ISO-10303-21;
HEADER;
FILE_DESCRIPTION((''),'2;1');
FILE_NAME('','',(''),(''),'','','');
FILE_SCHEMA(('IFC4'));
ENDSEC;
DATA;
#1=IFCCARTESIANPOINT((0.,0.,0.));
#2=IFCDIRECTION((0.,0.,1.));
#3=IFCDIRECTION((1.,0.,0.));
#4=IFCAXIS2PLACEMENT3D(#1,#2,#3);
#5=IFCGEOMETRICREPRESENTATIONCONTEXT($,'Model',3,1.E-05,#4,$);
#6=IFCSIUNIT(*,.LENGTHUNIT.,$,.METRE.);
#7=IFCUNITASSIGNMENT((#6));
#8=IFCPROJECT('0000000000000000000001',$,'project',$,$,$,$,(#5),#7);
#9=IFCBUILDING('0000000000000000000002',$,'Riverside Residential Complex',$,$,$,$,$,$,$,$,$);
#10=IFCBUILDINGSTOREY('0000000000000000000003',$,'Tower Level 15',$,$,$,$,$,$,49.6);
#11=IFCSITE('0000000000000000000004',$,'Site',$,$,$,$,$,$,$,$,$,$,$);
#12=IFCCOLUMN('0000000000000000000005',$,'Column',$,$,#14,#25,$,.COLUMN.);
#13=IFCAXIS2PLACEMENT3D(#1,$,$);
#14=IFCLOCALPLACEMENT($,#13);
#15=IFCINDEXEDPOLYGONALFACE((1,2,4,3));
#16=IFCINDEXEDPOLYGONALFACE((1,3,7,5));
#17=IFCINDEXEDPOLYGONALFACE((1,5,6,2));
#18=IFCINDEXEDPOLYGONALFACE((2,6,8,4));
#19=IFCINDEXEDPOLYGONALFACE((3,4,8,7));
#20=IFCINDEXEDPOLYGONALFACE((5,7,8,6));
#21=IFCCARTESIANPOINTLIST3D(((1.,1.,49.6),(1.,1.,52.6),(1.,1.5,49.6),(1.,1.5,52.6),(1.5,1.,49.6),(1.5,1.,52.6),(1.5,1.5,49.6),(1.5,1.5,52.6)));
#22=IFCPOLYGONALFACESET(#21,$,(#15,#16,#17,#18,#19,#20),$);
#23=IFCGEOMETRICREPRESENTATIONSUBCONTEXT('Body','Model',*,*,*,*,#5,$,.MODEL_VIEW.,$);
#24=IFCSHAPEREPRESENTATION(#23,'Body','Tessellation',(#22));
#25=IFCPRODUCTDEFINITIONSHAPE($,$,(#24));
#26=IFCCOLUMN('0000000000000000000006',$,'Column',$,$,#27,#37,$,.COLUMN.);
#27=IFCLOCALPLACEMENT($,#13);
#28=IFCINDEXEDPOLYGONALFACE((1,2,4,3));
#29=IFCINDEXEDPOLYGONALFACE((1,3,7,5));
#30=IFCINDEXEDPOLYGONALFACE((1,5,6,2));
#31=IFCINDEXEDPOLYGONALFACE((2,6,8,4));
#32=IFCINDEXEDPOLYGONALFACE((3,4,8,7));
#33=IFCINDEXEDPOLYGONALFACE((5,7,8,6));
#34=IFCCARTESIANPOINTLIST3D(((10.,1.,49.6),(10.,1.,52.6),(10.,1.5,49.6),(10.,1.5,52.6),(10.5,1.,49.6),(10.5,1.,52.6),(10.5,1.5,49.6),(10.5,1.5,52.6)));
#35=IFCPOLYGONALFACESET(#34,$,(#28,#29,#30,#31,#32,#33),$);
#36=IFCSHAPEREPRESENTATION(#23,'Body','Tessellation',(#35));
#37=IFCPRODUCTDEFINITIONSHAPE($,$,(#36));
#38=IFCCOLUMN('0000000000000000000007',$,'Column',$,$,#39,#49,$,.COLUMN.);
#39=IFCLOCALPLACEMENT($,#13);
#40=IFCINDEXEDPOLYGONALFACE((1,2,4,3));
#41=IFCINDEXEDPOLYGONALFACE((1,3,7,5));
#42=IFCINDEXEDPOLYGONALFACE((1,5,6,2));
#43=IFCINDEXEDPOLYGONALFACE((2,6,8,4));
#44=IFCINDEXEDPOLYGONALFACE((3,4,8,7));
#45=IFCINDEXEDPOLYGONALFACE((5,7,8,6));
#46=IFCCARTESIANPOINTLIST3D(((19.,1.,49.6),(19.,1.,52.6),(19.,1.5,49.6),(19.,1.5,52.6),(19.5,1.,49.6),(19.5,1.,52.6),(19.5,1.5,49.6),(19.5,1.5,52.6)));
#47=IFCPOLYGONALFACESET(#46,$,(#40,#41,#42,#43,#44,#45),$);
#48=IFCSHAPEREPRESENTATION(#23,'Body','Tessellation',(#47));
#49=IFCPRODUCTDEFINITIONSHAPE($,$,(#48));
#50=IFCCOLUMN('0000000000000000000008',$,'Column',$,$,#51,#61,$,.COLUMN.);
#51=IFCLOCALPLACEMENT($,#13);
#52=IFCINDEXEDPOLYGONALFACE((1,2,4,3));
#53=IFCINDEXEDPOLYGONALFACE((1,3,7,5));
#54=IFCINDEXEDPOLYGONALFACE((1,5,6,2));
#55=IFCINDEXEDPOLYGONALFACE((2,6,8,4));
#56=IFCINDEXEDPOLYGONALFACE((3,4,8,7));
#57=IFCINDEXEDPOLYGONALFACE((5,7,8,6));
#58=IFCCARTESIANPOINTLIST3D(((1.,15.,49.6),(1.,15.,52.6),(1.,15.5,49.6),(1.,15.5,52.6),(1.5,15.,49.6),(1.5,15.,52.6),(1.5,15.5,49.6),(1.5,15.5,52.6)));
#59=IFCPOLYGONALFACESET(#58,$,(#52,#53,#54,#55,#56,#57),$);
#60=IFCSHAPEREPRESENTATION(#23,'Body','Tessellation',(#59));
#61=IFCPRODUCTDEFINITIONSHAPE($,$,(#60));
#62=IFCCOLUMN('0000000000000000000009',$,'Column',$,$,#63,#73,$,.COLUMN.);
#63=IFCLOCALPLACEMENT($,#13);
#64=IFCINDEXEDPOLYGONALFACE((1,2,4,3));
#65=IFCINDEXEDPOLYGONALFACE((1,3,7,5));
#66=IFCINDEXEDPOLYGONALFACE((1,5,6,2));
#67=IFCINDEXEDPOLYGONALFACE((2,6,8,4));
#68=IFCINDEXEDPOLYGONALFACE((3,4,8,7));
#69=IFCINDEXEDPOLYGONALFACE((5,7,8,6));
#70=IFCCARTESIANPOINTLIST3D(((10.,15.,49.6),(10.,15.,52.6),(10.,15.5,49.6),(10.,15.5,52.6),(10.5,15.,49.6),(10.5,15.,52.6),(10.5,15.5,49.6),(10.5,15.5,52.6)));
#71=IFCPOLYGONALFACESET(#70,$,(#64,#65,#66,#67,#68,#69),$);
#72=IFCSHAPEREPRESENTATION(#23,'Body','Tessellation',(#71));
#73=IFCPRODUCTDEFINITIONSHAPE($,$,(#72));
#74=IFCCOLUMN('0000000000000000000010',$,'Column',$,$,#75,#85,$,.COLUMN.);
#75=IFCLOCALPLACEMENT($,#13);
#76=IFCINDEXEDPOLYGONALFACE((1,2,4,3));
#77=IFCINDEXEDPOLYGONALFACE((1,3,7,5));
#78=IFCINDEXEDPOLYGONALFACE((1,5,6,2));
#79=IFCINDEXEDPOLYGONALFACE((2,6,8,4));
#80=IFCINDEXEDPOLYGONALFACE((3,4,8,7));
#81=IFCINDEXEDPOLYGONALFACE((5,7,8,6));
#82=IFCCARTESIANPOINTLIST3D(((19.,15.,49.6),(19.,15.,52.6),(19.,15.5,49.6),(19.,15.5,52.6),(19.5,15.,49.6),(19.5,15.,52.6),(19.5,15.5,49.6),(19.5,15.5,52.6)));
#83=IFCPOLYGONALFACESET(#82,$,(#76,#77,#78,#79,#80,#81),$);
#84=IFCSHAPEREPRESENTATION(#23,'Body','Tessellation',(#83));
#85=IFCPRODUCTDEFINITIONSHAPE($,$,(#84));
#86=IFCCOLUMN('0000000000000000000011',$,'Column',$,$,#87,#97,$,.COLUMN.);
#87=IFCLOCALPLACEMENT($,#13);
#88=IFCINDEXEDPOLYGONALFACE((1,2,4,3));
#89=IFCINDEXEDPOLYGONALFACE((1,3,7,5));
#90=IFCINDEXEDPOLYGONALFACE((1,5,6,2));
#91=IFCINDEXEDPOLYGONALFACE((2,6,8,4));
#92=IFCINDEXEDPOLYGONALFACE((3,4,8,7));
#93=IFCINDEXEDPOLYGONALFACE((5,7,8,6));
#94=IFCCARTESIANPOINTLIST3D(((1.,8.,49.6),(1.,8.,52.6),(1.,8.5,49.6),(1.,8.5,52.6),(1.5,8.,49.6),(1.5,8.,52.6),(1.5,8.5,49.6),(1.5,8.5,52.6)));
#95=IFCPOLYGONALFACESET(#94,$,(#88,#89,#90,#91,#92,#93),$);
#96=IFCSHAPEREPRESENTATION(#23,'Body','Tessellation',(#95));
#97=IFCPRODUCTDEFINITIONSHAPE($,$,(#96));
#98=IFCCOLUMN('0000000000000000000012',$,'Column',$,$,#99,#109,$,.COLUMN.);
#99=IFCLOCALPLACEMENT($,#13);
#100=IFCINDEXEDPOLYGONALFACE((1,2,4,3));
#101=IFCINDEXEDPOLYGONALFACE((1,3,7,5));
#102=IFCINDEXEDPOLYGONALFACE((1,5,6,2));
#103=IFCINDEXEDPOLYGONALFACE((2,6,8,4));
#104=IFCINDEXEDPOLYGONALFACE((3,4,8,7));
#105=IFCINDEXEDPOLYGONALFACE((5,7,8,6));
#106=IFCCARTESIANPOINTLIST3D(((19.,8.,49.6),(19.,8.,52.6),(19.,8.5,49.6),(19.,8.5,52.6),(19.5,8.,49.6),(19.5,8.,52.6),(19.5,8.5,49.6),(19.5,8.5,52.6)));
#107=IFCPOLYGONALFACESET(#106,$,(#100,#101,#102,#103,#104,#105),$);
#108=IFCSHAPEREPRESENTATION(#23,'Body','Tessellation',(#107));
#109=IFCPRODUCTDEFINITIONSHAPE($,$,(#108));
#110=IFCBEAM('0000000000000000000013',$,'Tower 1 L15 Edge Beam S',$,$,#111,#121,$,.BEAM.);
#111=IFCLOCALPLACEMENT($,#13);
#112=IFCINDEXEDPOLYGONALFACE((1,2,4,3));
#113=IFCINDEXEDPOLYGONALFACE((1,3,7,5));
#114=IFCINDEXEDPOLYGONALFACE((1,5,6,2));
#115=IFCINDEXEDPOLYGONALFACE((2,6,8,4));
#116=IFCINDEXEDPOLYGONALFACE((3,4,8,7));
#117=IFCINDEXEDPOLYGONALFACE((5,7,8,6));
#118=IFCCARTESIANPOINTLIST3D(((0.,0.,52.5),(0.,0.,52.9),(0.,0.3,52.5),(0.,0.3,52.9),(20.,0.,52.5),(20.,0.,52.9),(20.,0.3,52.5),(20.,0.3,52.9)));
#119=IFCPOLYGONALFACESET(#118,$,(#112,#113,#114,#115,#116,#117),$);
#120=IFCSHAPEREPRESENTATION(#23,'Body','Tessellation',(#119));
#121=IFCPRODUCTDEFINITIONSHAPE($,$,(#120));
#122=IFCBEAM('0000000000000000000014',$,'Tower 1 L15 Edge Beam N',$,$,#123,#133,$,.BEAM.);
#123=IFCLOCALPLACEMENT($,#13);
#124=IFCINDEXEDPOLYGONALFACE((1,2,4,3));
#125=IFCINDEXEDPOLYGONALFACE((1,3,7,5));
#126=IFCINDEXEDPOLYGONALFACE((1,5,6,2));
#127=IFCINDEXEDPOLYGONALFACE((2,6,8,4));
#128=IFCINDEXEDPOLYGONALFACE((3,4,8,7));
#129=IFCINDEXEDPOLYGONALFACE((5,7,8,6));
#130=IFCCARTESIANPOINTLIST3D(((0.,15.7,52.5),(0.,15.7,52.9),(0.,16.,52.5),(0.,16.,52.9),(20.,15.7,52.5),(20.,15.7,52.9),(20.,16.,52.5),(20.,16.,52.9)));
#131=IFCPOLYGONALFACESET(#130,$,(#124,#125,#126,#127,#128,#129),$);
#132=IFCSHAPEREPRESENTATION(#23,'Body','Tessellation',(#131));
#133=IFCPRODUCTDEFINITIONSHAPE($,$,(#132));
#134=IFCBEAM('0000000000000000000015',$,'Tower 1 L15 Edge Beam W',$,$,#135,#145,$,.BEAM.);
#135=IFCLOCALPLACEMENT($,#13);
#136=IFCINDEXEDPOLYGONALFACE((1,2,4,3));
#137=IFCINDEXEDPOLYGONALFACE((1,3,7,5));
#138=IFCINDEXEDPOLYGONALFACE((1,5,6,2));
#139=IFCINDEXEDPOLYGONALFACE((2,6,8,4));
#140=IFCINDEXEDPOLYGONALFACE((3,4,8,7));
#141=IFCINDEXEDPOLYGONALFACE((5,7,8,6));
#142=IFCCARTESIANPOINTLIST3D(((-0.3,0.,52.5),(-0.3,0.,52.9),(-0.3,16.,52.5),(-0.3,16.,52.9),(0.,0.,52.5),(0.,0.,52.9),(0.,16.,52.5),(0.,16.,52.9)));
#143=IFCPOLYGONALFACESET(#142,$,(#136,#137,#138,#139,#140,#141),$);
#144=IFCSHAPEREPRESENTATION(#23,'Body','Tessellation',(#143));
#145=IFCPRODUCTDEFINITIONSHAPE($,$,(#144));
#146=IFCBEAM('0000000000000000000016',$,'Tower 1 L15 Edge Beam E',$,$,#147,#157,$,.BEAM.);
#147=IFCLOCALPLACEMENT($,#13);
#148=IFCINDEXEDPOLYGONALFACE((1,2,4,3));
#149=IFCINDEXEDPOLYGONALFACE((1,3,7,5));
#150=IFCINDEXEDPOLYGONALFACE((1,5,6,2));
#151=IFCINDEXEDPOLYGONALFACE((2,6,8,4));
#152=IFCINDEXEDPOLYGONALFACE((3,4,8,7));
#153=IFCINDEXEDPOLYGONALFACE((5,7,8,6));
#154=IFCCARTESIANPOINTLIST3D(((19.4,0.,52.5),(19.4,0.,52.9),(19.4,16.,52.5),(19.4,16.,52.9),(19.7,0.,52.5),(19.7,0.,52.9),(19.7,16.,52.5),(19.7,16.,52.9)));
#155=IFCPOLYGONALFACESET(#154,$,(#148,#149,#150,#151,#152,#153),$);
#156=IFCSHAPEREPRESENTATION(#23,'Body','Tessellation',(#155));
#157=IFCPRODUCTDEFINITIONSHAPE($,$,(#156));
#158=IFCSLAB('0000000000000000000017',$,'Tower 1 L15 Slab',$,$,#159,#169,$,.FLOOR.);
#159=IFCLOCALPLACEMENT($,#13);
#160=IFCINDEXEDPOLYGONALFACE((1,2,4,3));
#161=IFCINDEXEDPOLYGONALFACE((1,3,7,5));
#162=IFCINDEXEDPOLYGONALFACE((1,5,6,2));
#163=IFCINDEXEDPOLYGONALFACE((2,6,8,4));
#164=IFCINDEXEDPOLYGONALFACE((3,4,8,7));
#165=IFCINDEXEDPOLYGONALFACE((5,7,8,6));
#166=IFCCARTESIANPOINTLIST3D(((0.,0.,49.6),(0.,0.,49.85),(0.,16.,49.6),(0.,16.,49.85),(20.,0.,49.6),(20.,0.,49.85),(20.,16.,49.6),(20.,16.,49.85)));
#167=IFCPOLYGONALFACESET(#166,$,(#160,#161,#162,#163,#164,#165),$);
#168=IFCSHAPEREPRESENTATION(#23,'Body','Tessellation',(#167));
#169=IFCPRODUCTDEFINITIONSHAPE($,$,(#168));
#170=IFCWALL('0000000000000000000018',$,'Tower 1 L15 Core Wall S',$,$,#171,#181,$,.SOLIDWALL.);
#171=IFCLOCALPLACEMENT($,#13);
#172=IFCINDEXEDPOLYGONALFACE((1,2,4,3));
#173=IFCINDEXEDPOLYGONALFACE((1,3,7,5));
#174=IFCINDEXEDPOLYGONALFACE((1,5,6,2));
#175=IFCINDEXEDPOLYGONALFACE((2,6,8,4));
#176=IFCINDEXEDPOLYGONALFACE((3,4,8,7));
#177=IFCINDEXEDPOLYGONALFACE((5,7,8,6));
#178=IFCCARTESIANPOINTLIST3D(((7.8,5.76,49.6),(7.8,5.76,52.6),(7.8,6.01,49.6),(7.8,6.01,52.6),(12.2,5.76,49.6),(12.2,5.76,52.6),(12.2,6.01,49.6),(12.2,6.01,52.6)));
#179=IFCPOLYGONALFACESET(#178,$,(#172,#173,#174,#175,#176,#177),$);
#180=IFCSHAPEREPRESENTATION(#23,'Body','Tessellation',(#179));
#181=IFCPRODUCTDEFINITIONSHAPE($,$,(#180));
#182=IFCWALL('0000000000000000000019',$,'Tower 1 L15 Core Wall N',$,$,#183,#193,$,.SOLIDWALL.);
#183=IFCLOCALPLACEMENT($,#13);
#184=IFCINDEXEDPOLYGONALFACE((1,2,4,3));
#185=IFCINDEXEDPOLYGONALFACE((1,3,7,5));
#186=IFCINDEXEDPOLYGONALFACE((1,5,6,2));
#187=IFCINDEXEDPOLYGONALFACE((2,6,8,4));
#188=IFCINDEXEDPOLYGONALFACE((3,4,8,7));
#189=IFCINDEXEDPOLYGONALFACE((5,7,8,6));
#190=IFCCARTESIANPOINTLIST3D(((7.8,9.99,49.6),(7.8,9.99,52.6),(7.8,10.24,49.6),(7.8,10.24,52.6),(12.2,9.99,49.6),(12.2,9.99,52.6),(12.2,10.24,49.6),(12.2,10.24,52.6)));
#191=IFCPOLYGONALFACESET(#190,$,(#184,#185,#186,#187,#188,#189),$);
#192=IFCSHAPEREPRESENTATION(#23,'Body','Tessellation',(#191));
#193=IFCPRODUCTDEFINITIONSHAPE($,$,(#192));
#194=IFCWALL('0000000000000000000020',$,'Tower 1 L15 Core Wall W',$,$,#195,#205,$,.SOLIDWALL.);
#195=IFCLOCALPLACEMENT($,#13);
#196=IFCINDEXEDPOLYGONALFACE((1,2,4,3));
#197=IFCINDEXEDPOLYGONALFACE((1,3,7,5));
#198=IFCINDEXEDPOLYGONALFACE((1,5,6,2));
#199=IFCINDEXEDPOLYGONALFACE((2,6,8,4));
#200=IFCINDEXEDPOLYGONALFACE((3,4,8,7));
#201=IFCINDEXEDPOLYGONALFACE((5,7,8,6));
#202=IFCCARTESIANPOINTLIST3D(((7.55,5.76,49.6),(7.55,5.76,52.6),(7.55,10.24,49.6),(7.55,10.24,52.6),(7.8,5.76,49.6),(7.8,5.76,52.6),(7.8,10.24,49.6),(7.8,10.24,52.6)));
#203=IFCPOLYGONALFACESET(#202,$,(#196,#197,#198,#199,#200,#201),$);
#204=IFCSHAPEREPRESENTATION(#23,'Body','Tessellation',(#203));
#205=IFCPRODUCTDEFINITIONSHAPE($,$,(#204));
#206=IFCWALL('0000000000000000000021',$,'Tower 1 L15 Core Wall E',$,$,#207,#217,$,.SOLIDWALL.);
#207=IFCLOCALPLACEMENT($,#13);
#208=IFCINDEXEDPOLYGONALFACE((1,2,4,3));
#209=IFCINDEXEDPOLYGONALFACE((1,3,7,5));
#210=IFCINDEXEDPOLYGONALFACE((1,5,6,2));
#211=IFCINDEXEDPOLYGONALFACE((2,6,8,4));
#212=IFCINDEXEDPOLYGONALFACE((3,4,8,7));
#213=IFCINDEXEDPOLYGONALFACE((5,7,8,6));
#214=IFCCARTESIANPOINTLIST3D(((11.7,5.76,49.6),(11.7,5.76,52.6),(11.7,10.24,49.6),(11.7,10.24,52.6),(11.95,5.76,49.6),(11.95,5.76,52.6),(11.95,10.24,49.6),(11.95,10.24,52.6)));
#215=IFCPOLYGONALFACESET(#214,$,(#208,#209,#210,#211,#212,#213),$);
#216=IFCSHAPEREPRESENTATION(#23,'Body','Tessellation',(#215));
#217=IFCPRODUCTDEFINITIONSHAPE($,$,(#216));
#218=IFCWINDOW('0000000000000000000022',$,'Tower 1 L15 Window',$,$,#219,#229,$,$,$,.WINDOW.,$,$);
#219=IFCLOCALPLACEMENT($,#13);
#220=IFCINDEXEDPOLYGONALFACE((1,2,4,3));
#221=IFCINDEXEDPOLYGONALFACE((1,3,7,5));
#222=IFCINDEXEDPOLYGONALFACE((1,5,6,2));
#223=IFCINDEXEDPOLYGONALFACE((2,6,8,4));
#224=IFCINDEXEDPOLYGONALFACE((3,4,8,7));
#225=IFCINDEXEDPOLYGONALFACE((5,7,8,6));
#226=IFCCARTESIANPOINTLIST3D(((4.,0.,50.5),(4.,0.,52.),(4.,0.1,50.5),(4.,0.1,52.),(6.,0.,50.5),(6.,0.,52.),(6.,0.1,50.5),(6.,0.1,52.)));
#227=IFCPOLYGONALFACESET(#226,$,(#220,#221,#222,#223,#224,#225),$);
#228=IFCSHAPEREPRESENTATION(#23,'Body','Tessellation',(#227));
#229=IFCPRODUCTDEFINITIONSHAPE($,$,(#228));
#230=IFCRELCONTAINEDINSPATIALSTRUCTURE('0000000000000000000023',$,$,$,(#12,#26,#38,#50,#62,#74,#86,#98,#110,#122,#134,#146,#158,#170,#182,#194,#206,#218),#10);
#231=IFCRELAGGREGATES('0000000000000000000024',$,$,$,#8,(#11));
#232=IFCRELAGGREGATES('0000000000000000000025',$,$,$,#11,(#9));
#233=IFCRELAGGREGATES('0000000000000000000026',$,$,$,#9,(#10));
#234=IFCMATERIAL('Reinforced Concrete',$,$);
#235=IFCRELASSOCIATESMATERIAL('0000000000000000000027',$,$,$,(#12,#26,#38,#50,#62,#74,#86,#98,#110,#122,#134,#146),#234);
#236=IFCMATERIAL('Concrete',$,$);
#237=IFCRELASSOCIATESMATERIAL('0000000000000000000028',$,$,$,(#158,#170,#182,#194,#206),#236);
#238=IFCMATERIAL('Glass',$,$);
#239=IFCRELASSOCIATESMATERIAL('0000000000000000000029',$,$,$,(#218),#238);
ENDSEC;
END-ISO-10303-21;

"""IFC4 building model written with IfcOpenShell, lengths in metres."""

from ifc_helpers import new_model, si_unit, frame, origin_with_axes, place, context, subcontext, project, spatial, line, indexed_curve, outline, extrude, material, element, save


model = new_model("IFC4")

# Units and contexts
model_context = context("Model", 3, precision=1e-05, world=origin_with_axes())
body_context = subcontext(model_context, "Body", "Model", "MODEL_VIEW")
ifc_project = project(units=[si_unit("LENGTHUNIT", "METRE")], contexts=[model_context])

# Site, building, storey
site = spatial("IfcSite", under=ifc_project, Name="Site")
building = spatial("IfcBuilding", under=site, Name="Riverside Residential Complex")
storey = spatial("IfcBuildingStorey", under=building, Name="Tower Level 15", Elevation=49.6)

# Columns
ifc_material_1 = material(Name="Reinforced Concrete")
for number, where, z_axis, x_axis, name in (
    (1, (1.0, 1.0, 49.6), (0.0, 0.0, 1.0), (1.0, 0.0, 0.0), "Column"),
    (2, (10.0, 1.0, 49.6), (0.0, 0.0, 1.0), (1.0, 0.0, 0.0), "Column"),
    (3, (19.0, 1.0, 49.6), (0.0, 0.0, 1.0), (1.0, 0.0, 0.0), "Column"),
    (4, (1.0, 15.0, 49.6), (0.0, 0.0, 1.0), (1.0, 0.0, 0.0), "Column"),
    (5, (10.0, 15.0, 49.6), (0.0, 0.0, 1.0), (1.0, 0.0, 0.0), "Column"),
    (6, (19.0, 15.0, 49.6), (0.0, 0.0, 1.0), (1.0, 0.0, 0.0), "Column"),
    (7, (1.0, 8.0, 49.6), (0.0, 0.0, 1.0), (1.0, 0.0, 0.0), "Column"),
    (8, (19.0, 8.0, 49.6), (0.0, 0.0, 1.0), (1.0, 0.0, 0.0), "Column"),
):
    element("IfcColumn", number, at=place(None, frame(where, z_axis=z_axis, x_axis=x_axis)), inside=storey, material=ifc_material_1, Name=name, PredefinedType="COLUMN", context=body_context, shape_type="SweptSolid", body=[
        extrude(outline(indexed_curve([(0.0, 0.0), (0.5, 0.0), (0.5, 0.5), (0.0, 0.5)], segments=[line(1, 2, 3, 4, 1)])), origin_with_axes(), (0.0, 0.0, 1.0), 3.0),
    ])

# Beams
for number, where, z_axis, x_axis, name in (
    (9, (0.0, 0.0, 52.5), (0.0, 0.0, 1.0), (1.0, 0.0, 0.0), "Tower 1 L15 Edge Beam S"),
    (10, (0.0, 15.7, 52.5), (0.0, 0.0, 1.0), (1.0, 0.0, 0.0), "Tower 1 L15 Edge Beam N"),
):
    element("IfcBeam", number, at=place(None, frame(where, z_axis=z_axis, x_axis=x_axis)), inside=storey, material=ifc_material_1, Name=name, PredefinedType="BEAM", context=body_context, shape_type="SweptSolid", body=[
        extrude(outline(indexed_curve([(0.0, 0.0), (20.0, 0.0), (20.0, 0.3), (0.0, 0.3)], segments=[line(1, 2, 3, 4, 1)])), origin_with_axes(), (0.0, 0.0, 1.0), 0.4),
    ])
for number, where, z_axis, x_axis, name in (
    (11, (0.0, 0.0, 52.5), (0.0, 0.0, 1.0), (0.0, 1.0, 0.0), "Tower 1 L15 Edge Beam W"),
    (12, (19.7, 0.0, 52.5), (0.0, 0.0, 1.0), (0.0, 1.0, 0.0), "Tower 1 L15 Edge Beam E"),
):
    element("IfcBeam", number, at=place(None, frame(where, z_axis=z_axis, x_axis=x_axis)), inside=storey, material=ifc_material_1, Name=name, PredefinedType="BEAM", context=body_context, shape_type="SweptSolid", body=[
        extrude(outline(indexed_curve([(0.0, 0.0), (16.0, 0.0), (16.0, 0.3), (0.0, 0.3)], segments=[line(1, 2, 3, 4, 1)])), origin_with_axes(), (0.0, 0.0, 1.0), 0.4),
    ])

# Slab
ifc_material_2 = material(Name="Concrete")
slab_placement = place(None, frame((0.0, 0.0, 49.6), z_axis=(0.0, 0.0, 1.0), x_axis=(1.0, 0.0, 0.0)))
element("IfcSlab", 13, at=slab_placement, inside=storey, material=ifc_material_2, Name="Tower 1 L15 Slab", PredefinedType="FLOOR", context=body_context, shape_type="SweptSolid", body=[
    extrude(outline(indexed_curve([(0.0, 0.0), (20.0, 0.0), (20.0, 16.0), (0.0, 16.0)], segments=[line(1, 2, 3, 4, 1)])), origin_with_axes(), (0.0, 0.0, 1.0), 0.25),
])

# Walls
for number, where, z_axis, x_axis, name in (
    (14, (7.8, 5.76, 49.6), (0.0, 0.0, 1.0), (1.0, 0.0, 0.0), "Tower 1 L15 Core Wall S"),
    (15, (7.8, 9.99, 49.6), (0.0, 0.0, 1.0), (1.0, 0.0, 0.0), "Tower 1 L15 Core Wall N"),
):
    element("IfcWall", number, at=place(None, frame(where, z_axis=z_axis, x_axis=x_axis)), inside=storey, material=ifc_material_2, Name=name, PredefinedType="SOLIDWALL", context=body_context, shape_type="SweptSolid", body=[
        extrude(outline(indexed_curve([(0.0, 0.0), (4.4, 0.0), (4.4, 0.25), (0.0, 0.25)], segments=[line(1, 2, 3, 4, 1)])), origin_with_axes(), (0.0, 0.0, 1.0), 3.0),
    ])
for number, where, z_axis, x_axis, name in (
    (16, (7.8, 5.76, 49.6), (0.0, 0.0, 1.0), (0.0, 1.0, 0.0), "Tower 1 L15 Core Wall W"),
    (17, (11.95, 5.76, 49.6), (0.0, 0.0, 1.0), (0.0, 1.0, 0.0), "Tower 1 L15 Core Wall E"),
):
    element("IfcWall", number, at=place(None, frame(where, z_axis=z_axis, x_axis=x_axis)), inside=storey, material=ifc_material_2, Name=name, PredefinedType="SOLIDWALL", context=body_context, shape_type="SweptSolid", body=[
        extrude(outline(indexed_curve([(0.0, 0.0), (4.48, 0.0), (4.48, 0.25), (0.0, 0.25)], segments=[line(1, 2, 3, 4, 1)])), origin_with_axes(), (0.0, 0.0, 1.0), 3.0),
    ])

# Window
ifc_material_3 = material(Name="Glass")
for number, where, z_axis, x_axis, name in (
    (18, (4.0, 0.0, 50.5), (0.0, 0.0, 1.0), (1.0, 0.0, 0.0), "Tower 1 L15 Window"),
):
    element("IfcWindow", number, at=place(None, frame(where, z_axis=z_axis, x_axis=x_axis)), inside=storey, material=ifc_material_3, Name=name, PredefinedType="WINDOW", context=body_context, shape_type="SweptSolid", body=[
        extrude(outline(indexed_curve([(0.0, 0.0), (2.0, 0.0), (2.0, 0.1), (0.0, 0.1)], segments=[line(1, 2, 3, 4, 1)])), origin_with_axes(), (0.0, 0.0, 1.0), 1.5),
    ])

save(model, "model.ifc")
